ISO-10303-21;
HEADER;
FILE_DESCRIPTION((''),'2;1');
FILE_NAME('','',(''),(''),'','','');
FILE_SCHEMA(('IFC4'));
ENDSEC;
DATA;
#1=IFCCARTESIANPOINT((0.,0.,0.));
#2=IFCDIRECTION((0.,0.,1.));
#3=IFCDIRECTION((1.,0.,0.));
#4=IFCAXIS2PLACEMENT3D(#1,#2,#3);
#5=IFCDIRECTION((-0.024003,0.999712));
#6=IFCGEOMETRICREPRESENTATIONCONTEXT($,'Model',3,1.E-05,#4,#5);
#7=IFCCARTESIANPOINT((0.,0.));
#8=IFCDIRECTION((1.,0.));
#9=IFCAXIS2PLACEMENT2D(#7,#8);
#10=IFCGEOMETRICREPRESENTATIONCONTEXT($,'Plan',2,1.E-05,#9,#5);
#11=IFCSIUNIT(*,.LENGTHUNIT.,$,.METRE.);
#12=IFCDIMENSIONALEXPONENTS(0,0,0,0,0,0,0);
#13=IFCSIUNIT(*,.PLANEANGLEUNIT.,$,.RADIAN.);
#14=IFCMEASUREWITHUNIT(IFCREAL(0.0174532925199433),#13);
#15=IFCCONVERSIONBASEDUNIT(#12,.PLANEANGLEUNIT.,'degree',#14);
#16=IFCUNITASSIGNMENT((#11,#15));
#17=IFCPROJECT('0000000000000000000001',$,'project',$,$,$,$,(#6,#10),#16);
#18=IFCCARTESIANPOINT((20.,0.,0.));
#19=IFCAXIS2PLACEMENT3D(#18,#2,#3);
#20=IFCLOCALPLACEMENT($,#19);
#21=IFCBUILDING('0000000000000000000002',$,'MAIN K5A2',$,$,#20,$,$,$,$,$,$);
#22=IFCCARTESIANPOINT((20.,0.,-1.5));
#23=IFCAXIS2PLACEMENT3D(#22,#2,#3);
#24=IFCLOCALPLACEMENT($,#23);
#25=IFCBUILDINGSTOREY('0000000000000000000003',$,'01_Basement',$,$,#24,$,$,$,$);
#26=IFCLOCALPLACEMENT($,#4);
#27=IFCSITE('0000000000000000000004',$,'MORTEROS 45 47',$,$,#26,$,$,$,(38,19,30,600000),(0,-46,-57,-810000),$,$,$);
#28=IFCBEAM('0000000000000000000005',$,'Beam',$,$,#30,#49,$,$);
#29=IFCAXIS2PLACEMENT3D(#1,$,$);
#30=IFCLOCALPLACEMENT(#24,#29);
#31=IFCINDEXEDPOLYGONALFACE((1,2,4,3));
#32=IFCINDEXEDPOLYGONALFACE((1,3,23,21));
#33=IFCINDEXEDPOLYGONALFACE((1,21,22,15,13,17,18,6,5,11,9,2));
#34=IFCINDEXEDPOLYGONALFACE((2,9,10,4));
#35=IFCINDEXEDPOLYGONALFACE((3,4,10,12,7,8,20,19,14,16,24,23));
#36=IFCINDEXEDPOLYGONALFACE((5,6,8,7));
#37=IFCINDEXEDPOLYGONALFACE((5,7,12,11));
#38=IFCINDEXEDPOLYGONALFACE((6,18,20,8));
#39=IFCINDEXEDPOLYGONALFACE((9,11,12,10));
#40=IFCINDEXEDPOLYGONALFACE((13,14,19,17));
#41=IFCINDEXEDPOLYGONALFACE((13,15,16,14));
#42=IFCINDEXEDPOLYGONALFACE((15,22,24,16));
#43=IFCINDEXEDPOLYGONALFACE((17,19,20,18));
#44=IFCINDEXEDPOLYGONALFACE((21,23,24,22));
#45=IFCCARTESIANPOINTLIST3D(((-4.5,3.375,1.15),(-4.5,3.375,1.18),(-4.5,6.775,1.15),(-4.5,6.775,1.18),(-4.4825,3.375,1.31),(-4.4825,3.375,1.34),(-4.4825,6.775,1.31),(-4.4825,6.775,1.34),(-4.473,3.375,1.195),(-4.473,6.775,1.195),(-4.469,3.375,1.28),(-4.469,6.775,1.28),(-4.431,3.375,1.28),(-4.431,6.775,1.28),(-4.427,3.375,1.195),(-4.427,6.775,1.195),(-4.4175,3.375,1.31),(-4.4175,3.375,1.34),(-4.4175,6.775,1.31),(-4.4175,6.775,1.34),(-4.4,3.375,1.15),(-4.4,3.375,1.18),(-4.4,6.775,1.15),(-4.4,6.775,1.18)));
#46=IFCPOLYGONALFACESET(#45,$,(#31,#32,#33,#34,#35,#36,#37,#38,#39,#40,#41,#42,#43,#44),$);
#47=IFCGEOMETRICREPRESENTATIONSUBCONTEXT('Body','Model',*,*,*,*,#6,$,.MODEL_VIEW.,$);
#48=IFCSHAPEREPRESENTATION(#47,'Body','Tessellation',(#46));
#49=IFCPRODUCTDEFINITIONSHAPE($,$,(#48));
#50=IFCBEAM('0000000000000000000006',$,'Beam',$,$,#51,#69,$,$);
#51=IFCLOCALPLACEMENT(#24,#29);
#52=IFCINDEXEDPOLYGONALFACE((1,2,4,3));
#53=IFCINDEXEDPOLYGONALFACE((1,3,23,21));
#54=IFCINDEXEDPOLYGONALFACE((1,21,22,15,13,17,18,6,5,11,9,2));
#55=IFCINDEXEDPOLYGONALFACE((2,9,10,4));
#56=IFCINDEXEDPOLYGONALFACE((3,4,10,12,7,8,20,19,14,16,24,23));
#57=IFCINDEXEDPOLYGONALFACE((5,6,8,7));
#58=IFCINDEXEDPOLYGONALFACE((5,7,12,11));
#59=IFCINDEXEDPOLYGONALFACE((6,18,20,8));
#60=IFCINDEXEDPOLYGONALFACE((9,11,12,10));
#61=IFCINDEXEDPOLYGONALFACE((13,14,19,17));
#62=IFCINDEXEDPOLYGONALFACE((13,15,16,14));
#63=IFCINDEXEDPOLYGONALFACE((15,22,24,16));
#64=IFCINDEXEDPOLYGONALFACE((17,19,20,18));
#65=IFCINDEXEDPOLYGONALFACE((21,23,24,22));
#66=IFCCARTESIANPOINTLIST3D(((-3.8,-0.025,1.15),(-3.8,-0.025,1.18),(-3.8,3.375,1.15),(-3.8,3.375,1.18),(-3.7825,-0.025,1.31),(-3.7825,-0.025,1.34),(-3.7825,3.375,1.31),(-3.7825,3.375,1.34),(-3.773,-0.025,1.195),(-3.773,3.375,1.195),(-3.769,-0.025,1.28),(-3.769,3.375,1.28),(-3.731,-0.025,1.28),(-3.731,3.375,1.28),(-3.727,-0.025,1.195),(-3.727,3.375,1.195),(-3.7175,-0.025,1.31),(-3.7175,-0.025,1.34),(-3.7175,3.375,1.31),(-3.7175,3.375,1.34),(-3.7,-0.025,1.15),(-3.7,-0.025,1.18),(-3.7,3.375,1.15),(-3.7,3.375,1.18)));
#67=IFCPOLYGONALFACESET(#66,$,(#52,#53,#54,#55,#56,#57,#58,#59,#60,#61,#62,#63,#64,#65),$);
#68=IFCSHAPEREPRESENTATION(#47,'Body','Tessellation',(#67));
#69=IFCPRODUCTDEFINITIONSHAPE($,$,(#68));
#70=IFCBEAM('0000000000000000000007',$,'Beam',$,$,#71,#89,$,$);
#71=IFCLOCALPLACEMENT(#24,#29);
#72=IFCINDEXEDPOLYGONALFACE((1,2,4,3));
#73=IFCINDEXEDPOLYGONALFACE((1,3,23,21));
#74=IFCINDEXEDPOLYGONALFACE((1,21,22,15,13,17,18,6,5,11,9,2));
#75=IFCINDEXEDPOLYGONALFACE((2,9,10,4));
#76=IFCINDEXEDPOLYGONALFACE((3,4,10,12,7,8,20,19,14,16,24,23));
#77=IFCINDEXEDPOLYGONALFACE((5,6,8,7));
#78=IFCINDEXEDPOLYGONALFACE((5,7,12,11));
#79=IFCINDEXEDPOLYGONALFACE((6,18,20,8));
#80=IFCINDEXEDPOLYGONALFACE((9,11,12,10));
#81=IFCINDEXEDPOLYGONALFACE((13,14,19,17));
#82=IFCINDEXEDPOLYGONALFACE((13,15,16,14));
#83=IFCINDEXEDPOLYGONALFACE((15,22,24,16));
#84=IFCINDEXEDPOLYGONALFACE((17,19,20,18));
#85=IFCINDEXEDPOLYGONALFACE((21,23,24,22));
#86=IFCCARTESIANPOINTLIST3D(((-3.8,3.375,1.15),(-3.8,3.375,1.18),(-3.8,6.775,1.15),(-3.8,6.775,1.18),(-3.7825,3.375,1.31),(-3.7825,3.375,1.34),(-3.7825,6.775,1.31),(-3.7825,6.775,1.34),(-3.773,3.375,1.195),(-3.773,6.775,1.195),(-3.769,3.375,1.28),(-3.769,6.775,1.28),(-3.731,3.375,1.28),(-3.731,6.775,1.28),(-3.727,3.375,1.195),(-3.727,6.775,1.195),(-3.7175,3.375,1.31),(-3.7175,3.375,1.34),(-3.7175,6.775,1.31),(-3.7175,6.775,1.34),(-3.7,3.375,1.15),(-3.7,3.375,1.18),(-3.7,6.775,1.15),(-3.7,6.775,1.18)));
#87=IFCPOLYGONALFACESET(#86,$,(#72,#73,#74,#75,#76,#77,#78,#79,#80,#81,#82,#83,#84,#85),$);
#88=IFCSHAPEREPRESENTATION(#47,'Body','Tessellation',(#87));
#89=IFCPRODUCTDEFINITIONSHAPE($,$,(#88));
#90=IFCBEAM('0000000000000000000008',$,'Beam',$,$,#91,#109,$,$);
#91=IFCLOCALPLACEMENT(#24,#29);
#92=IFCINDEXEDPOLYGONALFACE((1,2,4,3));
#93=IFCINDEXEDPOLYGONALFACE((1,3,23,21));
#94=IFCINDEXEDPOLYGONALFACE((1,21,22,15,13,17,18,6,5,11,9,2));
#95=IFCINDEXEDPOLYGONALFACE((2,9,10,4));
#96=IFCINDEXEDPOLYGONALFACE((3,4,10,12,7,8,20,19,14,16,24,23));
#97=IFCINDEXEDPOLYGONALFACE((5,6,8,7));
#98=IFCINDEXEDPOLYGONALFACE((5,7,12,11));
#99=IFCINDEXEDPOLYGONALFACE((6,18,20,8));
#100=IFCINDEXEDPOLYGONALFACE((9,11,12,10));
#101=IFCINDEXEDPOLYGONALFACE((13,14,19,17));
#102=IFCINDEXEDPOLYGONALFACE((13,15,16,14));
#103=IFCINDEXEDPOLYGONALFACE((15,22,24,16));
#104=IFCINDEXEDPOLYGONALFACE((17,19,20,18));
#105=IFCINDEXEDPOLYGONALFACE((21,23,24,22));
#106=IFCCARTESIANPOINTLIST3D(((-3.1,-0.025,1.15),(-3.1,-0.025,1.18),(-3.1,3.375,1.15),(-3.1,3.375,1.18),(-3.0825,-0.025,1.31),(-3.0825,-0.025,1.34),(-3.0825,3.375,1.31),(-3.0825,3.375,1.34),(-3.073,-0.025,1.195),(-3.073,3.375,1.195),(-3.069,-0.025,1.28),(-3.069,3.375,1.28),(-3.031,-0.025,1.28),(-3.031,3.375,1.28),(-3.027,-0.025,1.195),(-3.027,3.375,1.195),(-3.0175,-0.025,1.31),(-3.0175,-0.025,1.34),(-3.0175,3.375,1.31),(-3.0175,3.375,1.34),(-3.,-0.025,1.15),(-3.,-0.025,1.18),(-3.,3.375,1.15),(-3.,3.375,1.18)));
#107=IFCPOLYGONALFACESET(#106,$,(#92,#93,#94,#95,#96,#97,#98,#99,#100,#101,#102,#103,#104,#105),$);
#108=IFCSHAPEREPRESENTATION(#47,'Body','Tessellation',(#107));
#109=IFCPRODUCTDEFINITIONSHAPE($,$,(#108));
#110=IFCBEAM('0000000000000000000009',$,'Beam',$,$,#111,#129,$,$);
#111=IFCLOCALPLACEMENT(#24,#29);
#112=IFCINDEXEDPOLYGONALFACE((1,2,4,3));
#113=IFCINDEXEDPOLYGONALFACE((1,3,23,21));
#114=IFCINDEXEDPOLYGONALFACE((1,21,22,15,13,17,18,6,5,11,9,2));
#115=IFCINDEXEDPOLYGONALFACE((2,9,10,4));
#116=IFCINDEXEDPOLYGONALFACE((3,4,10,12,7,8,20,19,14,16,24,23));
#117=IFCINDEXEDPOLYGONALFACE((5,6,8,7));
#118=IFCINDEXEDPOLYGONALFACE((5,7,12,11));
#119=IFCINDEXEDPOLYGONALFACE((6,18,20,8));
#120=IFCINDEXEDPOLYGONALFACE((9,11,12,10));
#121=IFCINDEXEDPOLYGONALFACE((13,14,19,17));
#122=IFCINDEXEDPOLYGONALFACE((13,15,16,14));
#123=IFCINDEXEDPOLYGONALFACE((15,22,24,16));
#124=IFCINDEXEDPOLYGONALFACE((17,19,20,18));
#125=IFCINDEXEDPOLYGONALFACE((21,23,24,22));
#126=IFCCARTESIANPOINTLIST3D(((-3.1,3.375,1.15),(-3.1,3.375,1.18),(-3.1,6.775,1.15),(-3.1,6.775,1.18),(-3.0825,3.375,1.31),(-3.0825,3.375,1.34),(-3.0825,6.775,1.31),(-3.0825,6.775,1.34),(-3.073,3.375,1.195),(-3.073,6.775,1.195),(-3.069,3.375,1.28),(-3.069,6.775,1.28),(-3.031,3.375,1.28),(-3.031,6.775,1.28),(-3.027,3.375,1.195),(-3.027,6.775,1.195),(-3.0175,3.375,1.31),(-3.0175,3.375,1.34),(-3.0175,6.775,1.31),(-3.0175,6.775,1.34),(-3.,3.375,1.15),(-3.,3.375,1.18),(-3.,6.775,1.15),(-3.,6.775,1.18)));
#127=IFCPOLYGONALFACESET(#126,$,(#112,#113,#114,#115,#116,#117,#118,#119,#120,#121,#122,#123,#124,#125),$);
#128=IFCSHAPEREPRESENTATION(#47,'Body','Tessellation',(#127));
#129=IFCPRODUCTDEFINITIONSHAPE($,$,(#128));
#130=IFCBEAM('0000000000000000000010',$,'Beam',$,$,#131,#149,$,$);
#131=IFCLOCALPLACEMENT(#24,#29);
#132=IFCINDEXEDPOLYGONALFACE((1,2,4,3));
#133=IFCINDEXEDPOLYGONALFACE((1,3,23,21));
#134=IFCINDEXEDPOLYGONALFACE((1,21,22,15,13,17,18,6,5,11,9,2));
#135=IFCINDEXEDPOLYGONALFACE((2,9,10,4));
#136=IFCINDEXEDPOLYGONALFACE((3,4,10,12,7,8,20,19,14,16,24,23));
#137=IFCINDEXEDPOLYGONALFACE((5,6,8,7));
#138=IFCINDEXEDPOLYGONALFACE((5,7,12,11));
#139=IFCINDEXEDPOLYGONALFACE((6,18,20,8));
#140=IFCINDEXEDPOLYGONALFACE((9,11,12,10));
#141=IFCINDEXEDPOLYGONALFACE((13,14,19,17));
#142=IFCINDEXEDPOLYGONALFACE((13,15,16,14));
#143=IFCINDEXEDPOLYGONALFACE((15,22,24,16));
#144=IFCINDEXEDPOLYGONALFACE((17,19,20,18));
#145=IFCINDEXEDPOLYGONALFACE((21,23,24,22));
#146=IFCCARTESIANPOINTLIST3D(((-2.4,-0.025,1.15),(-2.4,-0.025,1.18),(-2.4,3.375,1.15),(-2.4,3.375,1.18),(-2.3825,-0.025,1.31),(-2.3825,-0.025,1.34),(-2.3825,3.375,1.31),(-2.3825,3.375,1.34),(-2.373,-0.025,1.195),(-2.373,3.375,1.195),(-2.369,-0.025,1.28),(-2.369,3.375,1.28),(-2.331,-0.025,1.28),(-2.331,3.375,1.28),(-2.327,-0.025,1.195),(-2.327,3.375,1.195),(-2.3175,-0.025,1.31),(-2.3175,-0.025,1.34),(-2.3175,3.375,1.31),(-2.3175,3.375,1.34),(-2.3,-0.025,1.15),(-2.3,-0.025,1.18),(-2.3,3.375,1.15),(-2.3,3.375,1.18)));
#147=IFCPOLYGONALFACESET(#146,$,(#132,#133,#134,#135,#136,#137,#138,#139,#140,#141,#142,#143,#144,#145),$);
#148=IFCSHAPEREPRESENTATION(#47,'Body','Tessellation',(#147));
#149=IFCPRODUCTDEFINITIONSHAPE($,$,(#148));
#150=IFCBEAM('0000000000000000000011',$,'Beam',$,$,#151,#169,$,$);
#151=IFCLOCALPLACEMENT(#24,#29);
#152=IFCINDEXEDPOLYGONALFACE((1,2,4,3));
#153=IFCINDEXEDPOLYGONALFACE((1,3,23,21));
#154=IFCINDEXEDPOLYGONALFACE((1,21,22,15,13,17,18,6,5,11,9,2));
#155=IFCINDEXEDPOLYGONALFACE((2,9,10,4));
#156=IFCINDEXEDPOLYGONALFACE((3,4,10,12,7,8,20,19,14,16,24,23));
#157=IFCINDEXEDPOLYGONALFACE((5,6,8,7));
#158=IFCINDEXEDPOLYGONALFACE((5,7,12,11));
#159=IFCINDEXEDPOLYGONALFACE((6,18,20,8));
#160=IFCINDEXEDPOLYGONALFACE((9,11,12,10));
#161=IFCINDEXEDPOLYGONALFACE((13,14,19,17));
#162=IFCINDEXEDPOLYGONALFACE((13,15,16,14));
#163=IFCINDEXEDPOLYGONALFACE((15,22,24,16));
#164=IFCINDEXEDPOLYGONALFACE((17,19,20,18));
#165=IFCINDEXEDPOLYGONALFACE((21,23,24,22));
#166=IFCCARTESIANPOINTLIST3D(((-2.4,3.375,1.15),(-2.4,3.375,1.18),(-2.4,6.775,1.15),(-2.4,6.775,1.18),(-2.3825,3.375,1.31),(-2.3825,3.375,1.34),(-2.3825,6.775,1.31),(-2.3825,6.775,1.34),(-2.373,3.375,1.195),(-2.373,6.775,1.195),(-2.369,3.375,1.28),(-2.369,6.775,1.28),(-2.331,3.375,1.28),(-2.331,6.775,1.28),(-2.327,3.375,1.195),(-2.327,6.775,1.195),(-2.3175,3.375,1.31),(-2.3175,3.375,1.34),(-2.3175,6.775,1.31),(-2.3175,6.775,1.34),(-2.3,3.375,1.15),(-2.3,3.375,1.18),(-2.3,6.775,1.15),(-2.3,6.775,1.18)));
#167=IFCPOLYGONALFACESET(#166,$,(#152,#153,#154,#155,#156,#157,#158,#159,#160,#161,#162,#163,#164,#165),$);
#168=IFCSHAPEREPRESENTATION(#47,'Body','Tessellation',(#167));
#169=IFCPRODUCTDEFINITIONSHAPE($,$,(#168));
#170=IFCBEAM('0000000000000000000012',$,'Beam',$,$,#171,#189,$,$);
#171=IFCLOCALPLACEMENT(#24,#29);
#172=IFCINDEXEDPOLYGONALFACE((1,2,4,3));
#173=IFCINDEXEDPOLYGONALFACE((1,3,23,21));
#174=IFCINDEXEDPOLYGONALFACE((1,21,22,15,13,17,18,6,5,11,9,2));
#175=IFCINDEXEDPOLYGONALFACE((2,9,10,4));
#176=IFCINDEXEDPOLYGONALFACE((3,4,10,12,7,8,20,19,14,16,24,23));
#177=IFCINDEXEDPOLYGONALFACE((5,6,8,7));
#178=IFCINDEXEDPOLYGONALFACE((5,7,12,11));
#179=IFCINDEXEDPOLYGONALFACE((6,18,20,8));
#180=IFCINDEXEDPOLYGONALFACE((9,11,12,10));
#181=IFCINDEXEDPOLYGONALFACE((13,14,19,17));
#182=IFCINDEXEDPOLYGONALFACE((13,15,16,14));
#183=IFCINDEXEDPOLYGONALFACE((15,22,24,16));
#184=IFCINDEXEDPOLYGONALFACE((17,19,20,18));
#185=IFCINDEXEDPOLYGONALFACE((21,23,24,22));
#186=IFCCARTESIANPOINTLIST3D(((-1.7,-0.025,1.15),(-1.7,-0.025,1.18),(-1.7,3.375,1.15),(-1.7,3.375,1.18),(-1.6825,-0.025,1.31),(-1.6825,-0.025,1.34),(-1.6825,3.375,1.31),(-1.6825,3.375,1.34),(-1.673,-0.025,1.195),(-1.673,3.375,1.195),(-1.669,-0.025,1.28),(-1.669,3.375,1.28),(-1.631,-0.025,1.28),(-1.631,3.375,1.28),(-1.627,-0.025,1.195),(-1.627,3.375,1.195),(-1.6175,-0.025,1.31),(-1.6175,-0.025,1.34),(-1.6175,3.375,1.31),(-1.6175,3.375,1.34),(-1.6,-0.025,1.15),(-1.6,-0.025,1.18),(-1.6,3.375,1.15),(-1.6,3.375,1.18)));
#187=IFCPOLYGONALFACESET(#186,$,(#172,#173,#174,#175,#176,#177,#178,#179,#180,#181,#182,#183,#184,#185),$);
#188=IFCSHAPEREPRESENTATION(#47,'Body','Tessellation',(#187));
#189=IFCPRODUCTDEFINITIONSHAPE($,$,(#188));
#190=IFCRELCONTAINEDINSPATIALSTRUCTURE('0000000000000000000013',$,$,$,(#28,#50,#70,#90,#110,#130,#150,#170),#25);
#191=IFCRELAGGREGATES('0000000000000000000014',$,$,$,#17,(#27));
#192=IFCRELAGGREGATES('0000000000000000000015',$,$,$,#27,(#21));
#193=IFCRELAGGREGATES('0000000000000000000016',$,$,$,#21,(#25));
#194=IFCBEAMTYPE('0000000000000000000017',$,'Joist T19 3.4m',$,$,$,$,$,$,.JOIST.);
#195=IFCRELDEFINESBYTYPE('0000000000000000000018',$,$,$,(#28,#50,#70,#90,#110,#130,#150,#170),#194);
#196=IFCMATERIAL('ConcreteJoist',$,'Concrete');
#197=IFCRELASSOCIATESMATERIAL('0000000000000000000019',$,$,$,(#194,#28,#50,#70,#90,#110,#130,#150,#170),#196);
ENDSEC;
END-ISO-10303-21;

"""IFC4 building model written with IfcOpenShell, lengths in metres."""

from ifc_helpers import new_model, entity, si_unit, converted_unit, direction, frame, origin_with_axes, origin_2d_with_axis, place, context, subcontext, project, spatial, indexed_curve, outline, extrude, material, material_profile, profile_set, profile_usage, type_object, element, save


model = new_model("IFC4")

# Units and contexts
model_context = context("Model", 3, precision=1e-05, world=origin_with_axes(), true_north=direction((-0.024003, 0.999712)))
plan_context = context("Plan", 2, precision=1e-05, world=origin_2d_with_axis(), true_north=direction((-0.024003, 0.999712)))
body_context = subcontext(model_context, "Body", "Model", "MODEL_VIEW")
ifc_project = project(units=[si_unit("LENGTHUNIT", "METRE"), converted_unit("PLANEANGLEUNIT", "degree", entity("IfcReal", 0.0174532925199433), si_unit("PLANEANGLEUNIT", "RADIAN"), dimensions=[0, 0, 0, 0, 0, 0, 0])], contexts=[model_context, plan_context])

# Site, building, storey
site_placement = place(None, origin_with_axes())
site = spatial("IfcSite", under=ifc_project, at=site_placement, Name="MORTEROS 45 47", RefLatitude=(38, 19, 30, 600000), RefLongitude=(0, -46, -57, -810000))
building_placement = place(None, frame((20.0, 0.0, 0.0), z_axis=(0.0, 0.0, 1.0), x_axis=(1.0, 0.0, 0.0)))
building = spatial("IfcBuilding", under=site, at=building_placement, Name="MAIN K5A2")
storey_placement = place(None, frame((20.0, 0.0, -1.5), z_axis=(0.0, 0.0, 1.0), x_axis=(1.0, 0.0, 0.0)))
storey = spatial("IfcBuildingStorey", under=building, at=storey_placement, Name="01_Basement")

# Beams
ifc_material = material(Name="ConcreteJoist", Category="Concrete")
ifc_material_profile = material_profile(ifc_material, outline(indexed_curve([(0.019, 0.13), (0.023, 0.045), (0.05, 0.03), (0.05, 0.0), (-0.05, 0.0), (-0.05, 0.03), (-0.023, 0.045), (-0.019, 0.13), (-0.0325, 0.16), (-0.0325, 0.19), (0.0325, 0.19), (0.0325, 0.16), (0.019, 0.13)])))
ifc_profile_set = profile_set([ifc_material_profile], Name="JoistMaterialProfileSet")
beam_type = type_object("IfcBeamType", Name="Joist T19 3.4m", PredefinedType="JOIST", material=ifc_profile_set)
ifc_profile_usage_1 = profile_usage(ifc_profile_set, cardinal=5)
beam_1_placement = place(None, frame((15.55, 3.375, -0.35), z_axis=(0.0, 1.0, 0.0), x_axis=(-1.0, 0.0, 0.0)))
element("IfcBeam", 1, at=beam_1_placement, inside=storey, type_object=beam_type, material=ifc_profile_usage_1, Name="Beam", context=body_context, shape_type="SweptSolid", body=[
    extrude(outline(indexed_curve([(0.019, 0.13), (0.023, 0.045), (0.05, 0.03), (0.05, 0.0), (-0.05, 0.0), (-0.05, 0.03), (-0.023, 0.045), (-0.019, 0.13), (-0.0325, 0.16), (-0.0325, 0.19), (0.0325, 0.19), (0.0325, 0.16), (0.019, 0.13)])), origin_with_axes(), (0.0, 0.0, 1.0), 3.4),
])
ifc_profile_usage_2 = profile_usage(ifc_profile_set, cardinal=5)
beam_2_placement = place(None, frame((16.25, -0.025, -0.35), z_axis=(0.0, 1.0, 0.0), x_axis=(-1.0, 0.0, 0.0)))
element("IfcBeam", 2, at=beam_2_placement, inside=storey, type_object=beam_type, material=ifc_profile_usage_2, Name="Beam", context=body_context, shape_type="SweptSolid", body=[
    extrude(outline(indexed_curve([(0.019, 0.13), (0.023, 0.045), (0.05, 0.03), (0.05, 0.0), (-0.05, 0.0), (-0.05, 0.03), (-0.023, 0.045), (-0.019, 0.13), (-0.0325, 0.16), (-0.0325, 0.19), (0.0325, 0.19), (0.0325, 0.16), (0.019, 0.13)])), origin_with_axes(), (0.0, 0.0, 1.0), 3.4),
])
ifc_profile_usage_3 = profile_usage(ifc_profile_set, cardinal=5)
beam_3_placement = place(None, frame((16.25, 3.375, -0.35), z_axis=(0.0, 1.0, 0.0), x_axis=(-1.0, 0.0, 0.0)))
element("IfcBeam", 3, at=beam_3_placement, inside=storey, type_object=beam_type, material=ifc_profile_usage_3, Name="Beam", context=body_context, shape_type="SweptSolid", body=[
    extrude(outline(indexed_curve([(0.019, 0.13), (0.023, 0.045), (0.05, 0.03), (0.05, 0.0), (-0.05, 0.0), (-0.05, 0.03), (-0.023, 0.045), (-0.019, 0.13), (-0.0325, 0.16), (-0.0325, 0.19), (0.0325, 0.19), (0.0325, 0.16), (0.019, 0.13)])), origin_with_axes(), (0.0, 0.0, 1.0), 3.4),
])
ifc_profile_usage_4 = profile_usage(ifc_profile_set, cardinal=5)
beam_4_placement = place(None, frame((16.95, -0.025, -0.35), z_axis=(0.0, 1.0, 0.0), x_axis=(-1.0, 0.0, 0.0)))
element("IfcBeam", 4, at=beam_4_placement, inside=storey, type_object=beam_type, material=ifc_profile_usage_4, Name="Beam", context=body_context, shape_type="SweptSolid", body=[
    extrude(outline(indexed_curve([(0.019, 0.13), (0.023, 0.045), (0.05, 0.03), (0.05, 0.0), (-0.05, 0.0), (-0.05, 0.03), (-0.023, 0.045), (-0.019, 0.13), (-0.0325, 0.16), (-0.0325, 0.19), (0.0325, 0.19), (0.0325, 0.16), (0.019, 0.13)])), origin_with_axes(), (0.0, 0.0, 1.0), 3.4),
])
ifc_profile_usage_5 = profile_usage(ifc_profile_set, cardinal=5)
beam_5_placement = place(None, frame((16.95, 3.375, -0.35), z_axis=(0.0, 1.0, 0.0), x_axis=(-1.0, 0.0, 0.0)))
element("IfcBeam", 5, at=beam_5_placement, inside=storey, type_object=beam_type, material=ifc_profile_usage_5, Name="Beam", context=body_context, shape_type="SweptSolid", body=[
    extrude(outline(indexed_curve([(0.019, 0.13), (0.023, 0.045), (0.05, 0.03), (0.05, 0.0), (-0.05, 0.0), (-0.05, 0.03), (-0.023, 0.045), (-0.019, 0.13), (-0.0325, 0.16), (-0.0325, 0.19), (0.0325, 0.19), (0.0325, 0.16), (0.019, 0.13)])), origin_with_axes(), (0.0, 0.0, 1.0), 3.4),
])
ifc_profile_usage_6 = profile_usage(ifc_profile_set, cardinal=5)
beam_6_placement = place(None, frame((17.65, -0.025, -0.35), z_axis=(0.0, 1.0, 0.0), x_axis=(-1.0, 0.0, 0.0)))
element("IfcBeam", 6, at=beam_6_placement, inside=storey, type_object=beam_type, material=ifc_profile_usage_6, Name="Beam", context=body_context, shape_type="SweptSolid", body=[
    extrude(outline(indexed_curve([(0.019, 0.13), (0.023, 0.045), (0.05, 0.03), (0.05, 0.0), (-0.05, 0.0), (-0.05, 0.03), (-0.023, 0.045), (-0.019, 0.13), (-0.0325, 0.16), (-0.0325, 0.19), (0.0325, 0.19), (0.0325, 0.16), (0.019, 0.13)])), origin_with_axes(), (0.0, 0.0, 1.0), 3.4),
])
ifc_profile_usage_7 = profile_usage(ifc_profile_set, cardinal=5)
beam_7_placement = place(None, frame((17.65, 3.375, -0.35), z_axis=(0.0, 1.0, 0.0), x_axis=(-1.0, 0.0, 0.0)))
element("IfcBeam", 7, at=beam_7_placement, inside=storey, type_object=beam_type, material=ifc_profile_usage_7, Name="Beam", context=body_context, shape_type="SweptSolid", body=[
    extrude(outline(indexed_curve([(0.019, 0.13), (0.023, 0.045), (0.05, 0.03), (0.05, 0.0), (-0.05, 0.0), (-0.05, 0.03), (-0.023, 0.045), (-0.019, 0.13), (-0.0325, 0.16), (-0.0325, 0.19), (0.0325, 0.19), (0.0325, 0.16), (0.019, 0.13)])), origin_with_axes(), (0.0, 0.0, 1.0), 3.4),
])
ifc_profile_usage_8 = profile_usage(ifc_profile_set, cardinal=5)
beam_8_placement = place(None, frame((18.35, -0.025, -0.35), z_axis=(0.0, 1.0, 0.0), x_axis=(-1.0, 0.0, 0.0)))
element("IfcBeam", 8, at=beam_8_placement, inside=storey, type_object=beam_type, material=ifc_profile_usage_8, Name="Beam", context=body_context, shape_type="SweptSolid", body=[
    extrude(outline(indexed_curve([(0.019, 0.13), (0.023, 0.045), (0.05, 0.03), (0.05, 0.0), (-0.05, 0.0), (-0.05, 0.03), (-0.023, 0.045), (-0.019, 0.13), (-0.0325, 0.16), (-0.0325, 0.19), (0.0325, 0.19), (0.0325, 0.16), (0.019, 0.13)])), origin_with_axes(), (0.0, 0.0, 1.0), 3.4),
])

save(model, "model.ifc")
